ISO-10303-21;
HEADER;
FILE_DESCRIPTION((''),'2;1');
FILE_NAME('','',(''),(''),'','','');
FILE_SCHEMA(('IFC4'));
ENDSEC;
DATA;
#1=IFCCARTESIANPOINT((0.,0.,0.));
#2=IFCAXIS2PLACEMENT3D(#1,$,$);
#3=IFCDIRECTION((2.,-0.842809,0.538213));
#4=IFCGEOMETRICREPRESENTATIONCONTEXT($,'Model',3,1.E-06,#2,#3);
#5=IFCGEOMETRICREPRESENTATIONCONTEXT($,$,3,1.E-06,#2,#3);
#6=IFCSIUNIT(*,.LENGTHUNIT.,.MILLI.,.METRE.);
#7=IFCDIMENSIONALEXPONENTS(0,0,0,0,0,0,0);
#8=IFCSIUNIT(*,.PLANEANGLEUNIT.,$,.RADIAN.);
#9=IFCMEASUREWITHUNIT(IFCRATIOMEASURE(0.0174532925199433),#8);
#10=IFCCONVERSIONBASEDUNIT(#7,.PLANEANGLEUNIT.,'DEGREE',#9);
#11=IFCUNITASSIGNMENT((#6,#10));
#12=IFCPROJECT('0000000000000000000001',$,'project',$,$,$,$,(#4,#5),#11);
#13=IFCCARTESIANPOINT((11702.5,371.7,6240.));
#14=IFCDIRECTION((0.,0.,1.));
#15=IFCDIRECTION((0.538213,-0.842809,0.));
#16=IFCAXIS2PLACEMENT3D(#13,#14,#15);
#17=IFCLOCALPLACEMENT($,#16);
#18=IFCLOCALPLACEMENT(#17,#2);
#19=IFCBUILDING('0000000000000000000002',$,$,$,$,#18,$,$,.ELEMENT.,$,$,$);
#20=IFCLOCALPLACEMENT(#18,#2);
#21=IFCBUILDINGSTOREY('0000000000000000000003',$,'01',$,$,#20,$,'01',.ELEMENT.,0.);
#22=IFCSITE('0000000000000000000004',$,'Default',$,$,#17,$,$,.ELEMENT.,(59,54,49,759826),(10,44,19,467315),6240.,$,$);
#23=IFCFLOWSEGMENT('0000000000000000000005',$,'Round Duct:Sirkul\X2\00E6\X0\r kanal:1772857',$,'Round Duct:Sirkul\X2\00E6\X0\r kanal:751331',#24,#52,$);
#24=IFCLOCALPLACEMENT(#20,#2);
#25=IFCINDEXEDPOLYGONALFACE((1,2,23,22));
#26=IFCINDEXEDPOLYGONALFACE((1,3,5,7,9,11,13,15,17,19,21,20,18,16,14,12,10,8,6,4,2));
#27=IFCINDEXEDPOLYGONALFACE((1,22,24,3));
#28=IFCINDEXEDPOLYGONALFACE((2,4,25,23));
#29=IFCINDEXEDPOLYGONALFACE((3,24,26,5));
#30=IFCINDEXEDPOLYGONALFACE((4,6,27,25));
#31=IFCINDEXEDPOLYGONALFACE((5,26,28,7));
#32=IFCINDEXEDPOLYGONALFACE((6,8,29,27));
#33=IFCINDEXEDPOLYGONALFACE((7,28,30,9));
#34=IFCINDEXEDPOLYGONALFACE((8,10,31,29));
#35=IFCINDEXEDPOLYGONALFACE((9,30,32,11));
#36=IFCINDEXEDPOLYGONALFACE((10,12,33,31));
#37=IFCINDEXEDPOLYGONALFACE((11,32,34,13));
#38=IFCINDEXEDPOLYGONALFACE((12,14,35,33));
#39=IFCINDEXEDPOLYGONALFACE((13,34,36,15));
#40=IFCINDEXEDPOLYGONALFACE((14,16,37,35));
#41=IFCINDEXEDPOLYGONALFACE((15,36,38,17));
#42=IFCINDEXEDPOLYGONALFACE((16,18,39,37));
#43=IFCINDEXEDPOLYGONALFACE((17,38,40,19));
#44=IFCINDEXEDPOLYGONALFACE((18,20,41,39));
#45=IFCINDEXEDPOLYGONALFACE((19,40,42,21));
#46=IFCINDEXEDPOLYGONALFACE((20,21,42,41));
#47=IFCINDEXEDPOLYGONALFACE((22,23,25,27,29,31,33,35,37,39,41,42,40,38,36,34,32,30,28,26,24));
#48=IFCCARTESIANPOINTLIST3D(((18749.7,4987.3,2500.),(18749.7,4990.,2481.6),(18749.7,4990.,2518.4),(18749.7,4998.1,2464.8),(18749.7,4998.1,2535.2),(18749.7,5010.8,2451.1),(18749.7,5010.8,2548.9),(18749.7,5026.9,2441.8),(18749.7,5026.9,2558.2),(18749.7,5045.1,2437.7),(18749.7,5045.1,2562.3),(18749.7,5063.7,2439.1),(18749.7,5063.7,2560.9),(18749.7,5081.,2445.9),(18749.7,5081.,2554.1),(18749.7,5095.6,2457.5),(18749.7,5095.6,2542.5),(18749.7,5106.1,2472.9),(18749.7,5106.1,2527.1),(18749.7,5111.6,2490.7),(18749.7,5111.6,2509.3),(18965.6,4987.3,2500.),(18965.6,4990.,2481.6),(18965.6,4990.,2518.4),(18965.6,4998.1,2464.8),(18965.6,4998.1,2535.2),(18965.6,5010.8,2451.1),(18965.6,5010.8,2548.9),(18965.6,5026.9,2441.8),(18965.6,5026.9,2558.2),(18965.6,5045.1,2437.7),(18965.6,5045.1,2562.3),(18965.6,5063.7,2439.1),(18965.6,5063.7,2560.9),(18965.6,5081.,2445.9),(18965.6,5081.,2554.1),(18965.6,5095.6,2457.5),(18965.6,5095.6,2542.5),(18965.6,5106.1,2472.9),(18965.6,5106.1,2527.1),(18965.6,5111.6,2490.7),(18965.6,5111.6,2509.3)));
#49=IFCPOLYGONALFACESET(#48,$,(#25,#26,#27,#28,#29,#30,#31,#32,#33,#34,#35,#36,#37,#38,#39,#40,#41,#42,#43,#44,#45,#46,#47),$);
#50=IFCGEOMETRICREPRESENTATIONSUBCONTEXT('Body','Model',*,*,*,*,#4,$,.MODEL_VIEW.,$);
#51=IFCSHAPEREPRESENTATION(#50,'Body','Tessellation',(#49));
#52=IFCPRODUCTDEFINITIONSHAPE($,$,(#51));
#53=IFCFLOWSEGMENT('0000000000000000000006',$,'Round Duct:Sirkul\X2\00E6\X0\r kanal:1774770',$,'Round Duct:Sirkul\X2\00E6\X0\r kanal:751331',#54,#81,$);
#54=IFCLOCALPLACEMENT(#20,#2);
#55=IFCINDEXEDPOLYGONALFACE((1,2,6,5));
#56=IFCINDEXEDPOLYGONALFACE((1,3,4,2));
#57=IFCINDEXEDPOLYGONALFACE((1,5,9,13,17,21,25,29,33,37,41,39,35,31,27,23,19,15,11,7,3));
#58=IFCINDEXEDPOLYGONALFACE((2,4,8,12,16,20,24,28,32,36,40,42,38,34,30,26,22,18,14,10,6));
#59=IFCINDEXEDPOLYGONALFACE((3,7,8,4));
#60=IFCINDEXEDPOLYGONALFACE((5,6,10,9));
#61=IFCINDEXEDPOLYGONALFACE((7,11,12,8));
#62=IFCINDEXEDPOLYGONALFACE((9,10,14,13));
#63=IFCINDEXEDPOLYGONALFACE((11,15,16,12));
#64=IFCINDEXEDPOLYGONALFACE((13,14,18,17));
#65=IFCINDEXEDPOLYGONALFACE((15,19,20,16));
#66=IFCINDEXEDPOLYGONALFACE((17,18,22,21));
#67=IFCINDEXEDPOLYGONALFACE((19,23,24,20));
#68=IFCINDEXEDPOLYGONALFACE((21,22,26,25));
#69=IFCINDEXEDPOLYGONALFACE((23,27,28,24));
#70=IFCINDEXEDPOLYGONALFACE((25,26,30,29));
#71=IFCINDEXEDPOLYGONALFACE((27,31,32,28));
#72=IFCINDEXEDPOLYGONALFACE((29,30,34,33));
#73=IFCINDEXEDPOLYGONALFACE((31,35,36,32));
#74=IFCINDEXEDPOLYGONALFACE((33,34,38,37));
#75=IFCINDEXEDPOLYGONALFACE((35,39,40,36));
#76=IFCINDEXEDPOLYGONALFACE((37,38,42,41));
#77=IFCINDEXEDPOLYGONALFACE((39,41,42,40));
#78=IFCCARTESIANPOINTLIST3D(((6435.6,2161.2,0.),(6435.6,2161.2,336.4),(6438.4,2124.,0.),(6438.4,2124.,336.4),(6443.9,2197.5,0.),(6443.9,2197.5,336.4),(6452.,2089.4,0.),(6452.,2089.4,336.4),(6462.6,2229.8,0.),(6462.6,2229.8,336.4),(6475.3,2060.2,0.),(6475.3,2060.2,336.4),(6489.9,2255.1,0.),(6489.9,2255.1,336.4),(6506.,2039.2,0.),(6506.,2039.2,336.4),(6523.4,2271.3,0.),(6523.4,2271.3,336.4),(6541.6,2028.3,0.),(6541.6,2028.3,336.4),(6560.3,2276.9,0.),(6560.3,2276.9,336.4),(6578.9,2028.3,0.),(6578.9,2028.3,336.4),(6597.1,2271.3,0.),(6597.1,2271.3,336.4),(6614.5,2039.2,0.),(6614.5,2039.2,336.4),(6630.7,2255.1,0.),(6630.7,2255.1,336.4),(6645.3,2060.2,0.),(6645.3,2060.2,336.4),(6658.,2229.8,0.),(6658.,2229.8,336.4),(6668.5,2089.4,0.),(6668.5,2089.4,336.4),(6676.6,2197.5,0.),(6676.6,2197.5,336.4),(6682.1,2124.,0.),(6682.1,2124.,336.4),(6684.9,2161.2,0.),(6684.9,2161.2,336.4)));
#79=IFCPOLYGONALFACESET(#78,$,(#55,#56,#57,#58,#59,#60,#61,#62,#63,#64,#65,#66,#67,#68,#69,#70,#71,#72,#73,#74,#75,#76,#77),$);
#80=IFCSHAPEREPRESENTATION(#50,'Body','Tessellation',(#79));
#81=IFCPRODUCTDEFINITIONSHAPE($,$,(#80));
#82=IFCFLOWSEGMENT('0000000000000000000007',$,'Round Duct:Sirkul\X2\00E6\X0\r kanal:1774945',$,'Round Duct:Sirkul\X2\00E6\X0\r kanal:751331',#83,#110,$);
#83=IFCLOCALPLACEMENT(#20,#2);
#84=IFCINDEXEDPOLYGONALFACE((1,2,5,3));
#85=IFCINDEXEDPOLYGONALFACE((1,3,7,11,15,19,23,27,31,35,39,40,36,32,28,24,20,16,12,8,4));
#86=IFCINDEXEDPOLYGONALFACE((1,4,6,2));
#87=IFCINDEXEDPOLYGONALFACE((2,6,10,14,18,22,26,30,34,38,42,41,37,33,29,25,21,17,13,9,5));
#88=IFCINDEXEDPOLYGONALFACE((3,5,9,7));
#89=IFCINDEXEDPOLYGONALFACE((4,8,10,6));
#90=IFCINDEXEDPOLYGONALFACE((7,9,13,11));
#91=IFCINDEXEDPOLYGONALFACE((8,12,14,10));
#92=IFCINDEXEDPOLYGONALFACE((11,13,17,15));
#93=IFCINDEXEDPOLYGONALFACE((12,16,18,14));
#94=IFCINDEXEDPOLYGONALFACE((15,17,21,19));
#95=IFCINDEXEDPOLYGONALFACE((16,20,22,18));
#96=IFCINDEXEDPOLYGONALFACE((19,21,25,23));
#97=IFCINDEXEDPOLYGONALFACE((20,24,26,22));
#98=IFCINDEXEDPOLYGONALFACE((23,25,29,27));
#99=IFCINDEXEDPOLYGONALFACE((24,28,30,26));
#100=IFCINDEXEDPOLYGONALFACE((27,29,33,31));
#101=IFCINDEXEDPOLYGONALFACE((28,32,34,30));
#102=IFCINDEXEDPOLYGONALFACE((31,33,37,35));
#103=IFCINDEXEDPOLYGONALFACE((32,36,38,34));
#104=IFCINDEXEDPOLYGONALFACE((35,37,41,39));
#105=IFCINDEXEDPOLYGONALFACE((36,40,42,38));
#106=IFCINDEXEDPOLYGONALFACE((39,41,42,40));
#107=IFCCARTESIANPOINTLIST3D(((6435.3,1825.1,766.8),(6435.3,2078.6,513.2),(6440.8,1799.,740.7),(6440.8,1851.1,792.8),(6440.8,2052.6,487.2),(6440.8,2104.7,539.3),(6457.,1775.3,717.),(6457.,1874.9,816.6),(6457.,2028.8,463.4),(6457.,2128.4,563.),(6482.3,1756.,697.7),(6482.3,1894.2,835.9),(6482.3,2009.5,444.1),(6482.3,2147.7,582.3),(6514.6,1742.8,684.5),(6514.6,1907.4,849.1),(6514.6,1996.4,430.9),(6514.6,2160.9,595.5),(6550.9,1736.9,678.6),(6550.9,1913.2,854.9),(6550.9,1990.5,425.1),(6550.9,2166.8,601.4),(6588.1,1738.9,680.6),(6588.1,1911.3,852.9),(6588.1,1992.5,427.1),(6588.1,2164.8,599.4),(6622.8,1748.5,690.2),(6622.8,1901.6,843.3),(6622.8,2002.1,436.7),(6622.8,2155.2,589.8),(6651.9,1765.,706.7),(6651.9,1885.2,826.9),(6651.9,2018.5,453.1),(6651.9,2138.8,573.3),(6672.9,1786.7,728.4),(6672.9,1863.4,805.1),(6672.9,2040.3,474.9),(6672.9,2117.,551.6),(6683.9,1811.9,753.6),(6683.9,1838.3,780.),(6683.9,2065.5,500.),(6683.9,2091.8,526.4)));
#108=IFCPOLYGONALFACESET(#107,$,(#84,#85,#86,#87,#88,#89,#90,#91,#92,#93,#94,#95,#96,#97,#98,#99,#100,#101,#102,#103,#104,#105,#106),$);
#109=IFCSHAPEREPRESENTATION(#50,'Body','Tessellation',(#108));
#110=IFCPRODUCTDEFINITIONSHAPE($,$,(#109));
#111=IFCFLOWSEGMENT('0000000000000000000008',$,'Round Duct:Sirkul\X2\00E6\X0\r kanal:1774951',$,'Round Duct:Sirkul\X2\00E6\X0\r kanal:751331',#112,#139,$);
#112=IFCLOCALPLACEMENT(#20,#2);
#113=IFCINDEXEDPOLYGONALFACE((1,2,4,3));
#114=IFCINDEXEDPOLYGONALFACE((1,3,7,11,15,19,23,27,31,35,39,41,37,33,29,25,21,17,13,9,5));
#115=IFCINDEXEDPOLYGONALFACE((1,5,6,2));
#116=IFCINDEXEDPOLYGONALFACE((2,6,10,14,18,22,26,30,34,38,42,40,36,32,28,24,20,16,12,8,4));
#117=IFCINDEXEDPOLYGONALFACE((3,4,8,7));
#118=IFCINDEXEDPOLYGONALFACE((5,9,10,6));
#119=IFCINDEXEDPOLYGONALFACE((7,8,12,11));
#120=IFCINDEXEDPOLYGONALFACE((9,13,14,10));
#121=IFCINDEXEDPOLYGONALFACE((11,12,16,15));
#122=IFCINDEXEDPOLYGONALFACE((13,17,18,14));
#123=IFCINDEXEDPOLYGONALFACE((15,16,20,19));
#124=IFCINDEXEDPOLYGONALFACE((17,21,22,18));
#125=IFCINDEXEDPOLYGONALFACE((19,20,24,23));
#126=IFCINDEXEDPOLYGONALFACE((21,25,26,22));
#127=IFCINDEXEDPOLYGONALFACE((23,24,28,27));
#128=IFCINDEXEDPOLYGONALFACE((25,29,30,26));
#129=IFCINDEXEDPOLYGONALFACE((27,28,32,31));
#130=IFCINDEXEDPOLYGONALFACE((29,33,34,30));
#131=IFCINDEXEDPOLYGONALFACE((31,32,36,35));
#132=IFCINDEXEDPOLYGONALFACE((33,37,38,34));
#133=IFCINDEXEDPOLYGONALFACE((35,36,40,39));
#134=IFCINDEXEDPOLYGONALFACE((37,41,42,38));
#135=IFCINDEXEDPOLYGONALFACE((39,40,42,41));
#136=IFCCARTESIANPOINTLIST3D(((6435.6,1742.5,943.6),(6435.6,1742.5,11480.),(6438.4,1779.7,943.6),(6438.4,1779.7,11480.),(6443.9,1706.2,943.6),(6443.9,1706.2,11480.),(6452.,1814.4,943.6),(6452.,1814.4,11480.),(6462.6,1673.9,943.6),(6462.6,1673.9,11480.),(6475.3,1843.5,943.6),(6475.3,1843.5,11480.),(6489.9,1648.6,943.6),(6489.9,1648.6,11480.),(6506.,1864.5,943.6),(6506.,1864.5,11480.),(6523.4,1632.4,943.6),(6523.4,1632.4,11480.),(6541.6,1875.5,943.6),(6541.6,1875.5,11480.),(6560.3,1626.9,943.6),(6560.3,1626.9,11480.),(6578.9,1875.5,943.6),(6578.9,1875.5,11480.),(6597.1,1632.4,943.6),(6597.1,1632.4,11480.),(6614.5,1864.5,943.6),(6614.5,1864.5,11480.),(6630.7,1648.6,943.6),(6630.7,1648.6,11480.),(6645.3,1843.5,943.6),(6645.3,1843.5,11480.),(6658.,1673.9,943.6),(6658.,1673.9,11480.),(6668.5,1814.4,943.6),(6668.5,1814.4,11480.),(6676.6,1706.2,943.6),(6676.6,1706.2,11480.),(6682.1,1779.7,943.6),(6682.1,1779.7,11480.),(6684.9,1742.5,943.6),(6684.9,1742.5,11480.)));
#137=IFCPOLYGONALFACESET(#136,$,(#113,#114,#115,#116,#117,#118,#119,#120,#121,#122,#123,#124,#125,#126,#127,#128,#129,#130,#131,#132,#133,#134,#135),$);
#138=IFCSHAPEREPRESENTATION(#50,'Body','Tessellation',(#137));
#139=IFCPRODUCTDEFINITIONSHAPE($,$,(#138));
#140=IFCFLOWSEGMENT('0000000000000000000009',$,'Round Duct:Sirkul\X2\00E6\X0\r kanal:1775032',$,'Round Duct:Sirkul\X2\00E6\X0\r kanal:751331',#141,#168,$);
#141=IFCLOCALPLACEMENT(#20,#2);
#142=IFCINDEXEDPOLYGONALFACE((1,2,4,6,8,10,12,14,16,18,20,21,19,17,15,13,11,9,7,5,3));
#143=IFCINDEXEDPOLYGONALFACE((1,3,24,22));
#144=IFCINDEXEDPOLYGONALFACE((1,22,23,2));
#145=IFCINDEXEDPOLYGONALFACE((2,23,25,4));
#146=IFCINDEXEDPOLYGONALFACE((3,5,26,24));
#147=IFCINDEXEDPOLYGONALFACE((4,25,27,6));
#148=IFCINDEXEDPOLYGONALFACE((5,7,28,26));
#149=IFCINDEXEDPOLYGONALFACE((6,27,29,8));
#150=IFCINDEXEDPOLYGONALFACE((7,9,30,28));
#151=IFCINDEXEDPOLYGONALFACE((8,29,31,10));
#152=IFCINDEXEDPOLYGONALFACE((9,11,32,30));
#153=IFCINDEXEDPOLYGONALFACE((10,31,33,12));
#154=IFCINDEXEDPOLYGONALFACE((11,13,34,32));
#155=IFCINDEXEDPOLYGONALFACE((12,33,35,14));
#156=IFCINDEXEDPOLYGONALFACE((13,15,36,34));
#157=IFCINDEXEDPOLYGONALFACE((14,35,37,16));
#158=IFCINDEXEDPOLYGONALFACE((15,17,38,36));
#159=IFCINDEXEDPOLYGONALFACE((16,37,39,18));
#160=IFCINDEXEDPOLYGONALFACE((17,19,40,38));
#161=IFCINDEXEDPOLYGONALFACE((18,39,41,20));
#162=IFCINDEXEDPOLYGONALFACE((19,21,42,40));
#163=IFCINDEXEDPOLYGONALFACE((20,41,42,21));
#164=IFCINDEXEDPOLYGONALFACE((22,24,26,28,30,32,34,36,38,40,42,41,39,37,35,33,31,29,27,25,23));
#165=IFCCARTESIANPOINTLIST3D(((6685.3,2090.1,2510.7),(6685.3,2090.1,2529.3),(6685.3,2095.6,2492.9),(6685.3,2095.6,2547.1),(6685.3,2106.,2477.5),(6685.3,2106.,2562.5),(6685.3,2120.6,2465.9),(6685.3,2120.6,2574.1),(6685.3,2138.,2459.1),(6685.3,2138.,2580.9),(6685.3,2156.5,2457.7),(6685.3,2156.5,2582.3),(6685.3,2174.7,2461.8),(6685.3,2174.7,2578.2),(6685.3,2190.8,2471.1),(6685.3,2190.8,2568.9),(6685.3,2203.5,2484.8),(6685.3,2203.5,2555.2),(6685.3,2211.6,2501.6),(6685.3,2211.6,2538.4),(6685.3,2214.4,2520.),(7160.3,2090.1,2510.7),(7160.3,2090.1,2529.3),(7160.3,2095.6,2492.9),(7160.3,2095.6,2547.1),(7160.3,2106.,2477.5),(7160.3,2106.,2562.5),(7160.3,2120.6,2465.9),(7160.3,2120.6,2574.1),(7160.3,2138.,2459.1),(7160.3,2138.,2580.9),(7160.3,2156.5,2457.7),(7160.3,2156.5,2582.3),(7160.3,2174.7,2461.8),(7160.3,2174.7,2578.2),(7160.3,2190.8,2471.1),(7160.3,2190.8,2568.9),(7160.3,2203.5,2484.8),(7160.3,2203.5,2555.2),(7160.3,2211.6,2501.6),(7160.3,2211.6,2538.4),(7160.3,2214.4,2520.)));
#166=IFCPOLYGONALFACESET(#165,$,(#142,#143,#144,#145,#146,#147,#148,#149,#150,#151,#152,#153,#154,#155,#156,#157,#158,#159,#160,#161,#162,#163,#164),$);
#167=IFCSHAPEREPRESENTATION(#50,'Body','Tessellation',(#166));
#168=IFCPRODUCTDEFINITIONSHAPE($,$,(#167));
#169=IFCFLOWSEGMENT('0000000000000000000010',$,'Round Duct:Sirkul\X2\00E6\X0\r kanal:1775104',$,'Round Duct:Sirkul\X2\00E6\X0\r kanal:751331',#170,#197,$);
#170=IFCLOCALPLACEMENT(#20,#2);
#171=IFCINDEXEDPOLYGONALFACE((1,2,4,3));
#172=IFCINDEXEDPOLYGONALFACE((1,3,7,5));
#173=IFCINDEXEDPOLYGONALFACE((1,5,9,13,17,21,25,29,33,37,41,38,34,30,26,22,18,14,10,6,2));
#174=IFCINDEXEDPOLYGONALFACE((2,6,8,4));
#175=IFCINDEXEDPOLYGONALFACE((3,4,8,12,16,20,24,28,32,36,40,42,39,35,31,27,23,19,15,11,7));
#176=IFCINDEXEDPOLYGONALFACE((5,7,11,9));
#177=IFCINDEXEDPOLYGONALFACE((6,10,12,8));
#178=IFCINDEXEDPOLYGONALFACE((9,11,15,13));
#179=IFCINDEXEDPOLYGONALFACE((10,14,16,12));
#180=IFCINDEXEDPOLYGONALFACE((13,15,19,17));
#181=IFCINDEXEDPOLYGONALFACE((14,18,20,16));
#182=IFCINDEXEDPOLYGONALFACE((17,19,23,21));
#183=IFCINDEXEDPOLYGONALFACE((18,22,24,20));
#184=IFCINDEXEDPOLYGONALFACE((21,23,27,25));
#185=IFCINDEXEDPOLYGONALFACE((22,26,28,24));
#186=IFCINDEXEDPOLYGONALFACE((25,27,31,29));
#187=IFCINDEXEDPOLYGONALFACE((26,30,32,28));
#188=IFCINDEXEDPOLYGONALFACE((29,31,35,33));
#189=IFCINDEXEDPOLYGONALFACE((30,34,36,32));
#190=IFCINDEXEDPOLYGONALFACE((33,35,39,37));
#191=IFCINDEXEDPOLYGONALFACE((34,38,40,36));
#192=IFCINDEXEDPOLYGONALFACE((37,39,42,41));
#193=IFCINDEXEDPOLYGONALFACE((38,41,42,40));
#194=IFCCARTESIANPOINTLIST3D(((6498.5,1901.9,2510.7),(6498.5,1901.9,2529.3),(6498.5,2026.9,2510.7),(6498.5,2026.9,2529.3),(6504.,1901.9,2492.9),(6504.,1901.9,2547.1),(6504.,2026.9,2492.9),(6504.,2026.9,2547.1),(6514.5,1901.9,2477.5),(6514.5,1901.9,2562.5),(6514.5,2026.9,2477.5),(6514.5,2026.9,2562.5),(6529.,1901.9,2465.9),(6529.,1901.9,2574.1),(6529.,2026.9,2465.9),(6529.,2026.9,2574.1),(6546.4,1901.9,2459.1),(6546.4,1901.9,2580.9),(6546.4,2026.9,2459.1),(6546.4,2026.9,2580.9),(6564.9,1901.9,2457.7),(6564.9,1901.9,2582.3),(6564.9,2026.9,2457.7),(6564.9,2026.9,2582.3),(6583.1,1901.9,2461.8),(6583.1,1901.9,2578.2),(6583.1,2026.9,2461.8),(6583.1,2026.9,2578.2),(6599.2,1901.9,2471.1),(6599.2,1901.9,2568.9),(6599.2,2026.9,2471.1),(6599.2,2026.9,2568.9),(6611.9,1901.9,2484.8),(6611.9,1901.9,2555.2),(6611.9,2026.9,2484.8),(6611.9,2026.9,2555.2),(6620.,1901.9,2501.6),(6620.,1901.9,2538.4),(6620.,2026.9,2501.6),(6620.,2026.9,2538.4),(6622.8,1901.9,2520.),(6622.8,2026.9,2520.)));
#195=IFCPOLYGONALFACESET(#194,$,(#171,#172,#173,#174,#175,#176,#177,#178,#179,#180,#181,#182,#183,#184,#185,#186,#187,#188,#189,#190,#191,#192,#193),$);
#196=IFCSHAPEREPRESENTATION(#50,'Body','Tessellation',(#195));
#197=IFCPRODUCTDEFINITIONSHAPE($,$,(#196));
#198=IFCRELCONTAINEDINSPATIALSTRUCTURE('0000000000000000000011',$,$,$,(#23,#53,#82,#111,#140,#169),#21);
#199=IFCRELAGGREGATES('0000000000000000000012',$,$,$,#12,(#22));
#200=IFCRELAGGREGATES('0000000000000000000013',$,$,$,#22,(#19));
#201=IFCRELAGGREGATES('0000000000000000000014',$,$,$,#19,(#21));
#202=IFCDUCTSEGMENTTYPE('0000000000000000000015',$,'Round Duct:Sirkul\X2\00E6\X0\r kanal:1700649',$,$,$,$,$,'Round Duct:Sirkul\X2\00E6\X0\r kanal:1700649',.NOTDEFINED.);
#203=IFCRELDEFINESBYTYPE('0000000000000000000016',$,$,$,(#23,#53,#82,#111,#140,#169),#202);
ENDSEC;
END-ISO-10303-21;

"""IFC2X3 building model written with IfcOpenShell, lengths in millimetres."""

from ifc_helpers import new_model, entity, si_unit, converted_unit, direction, frame, frame_2d, origin, origin_2d_with_axis, place, context, subcontext, project, spatial, circle, extrude, type_object, element, save


model = new_model("IFC2X3")

# Units and contexts
model_context = context("Model", 3, precision=1e-06, world=origin(), true_north=direction((2.0, -0.842809, 0.538213)))
context_of_model = context(None, 3, precision=1e-06, world=origin(), true_north=direction((2.0, -0.842809, 0.538213)))
body_context = subcontext(model_context, "Body", "Model", "MODEL_VIEW")
ifc_project = project(units=[si_unit("LENGTHUNIT", "METRE", prefix="MILLI"), converted_unit("PLANEANGLEUNIT", "DEGREE", entity("IfcRatioMeasure", 0.0174532925199433), si_unit("PLANEANGLEUNIT", "RADIAN"), dimensions=[0, 0, 0, 0, 0, 0, 0])], contexts=[model_context, context_of_model])

# Site, building, storey
site_placement = place(None, frame((11702.5, 371.7, 6240.0), z_axis=(0.0, 0.0, 1.0), x_axis=(0.538213, -0.842809, 0.0)))
site = spatial("IfcSite", under=ifc_project, at=site_placement, Name="Default", CompositionType="ELEMENT", RefLatitude=(59, 54, 49, 759826), RefLongitude=(10, 44, 19, 467315), RefElevation=6240.0)
building_placement = place(site_placement, origin())
building = spatial("IfcBuilding", under=site, at=building_placement, CompositionType="ELEMENT")
storey_placement = place(building_placement, origin())
storey = spatial("IfcBuildingStorey", under=building, at=storey_placement, Name="01", LongName="01", CompositionType="ELEMENT", Elevation=0.0)

# Flow segments
duct_segment_type = type_object("IfcDuctSegmentType", Name="Round Duct:Sirkulær kanal:1700649", ElementType="Round Duct:Sirkulær kanal:1700649", PredefinedType="NOTDEFINED")
flow_segment_1_placement = place(storey_placement, origin())
element("IfcFlowSegment", 1, at=flow_segment_1_placement, inside=storey, type_object=duct_segment_type, Name="Round Duct:Sirkulær kanal:1772857", ObjectType="Round Duct:Sirkulær kanal:751331", context=body_context, shape_type="SweptSolid", body=[
    extrude(circle(Radius=62.5, at=origin_2d_with_axis()), frame((18749.7, 5049.8, 2500.0), z_axis=(1.0, 0.0, 0.0), x_axis=(0.0, -1.0, 0.0)), (0.0, 0.0, 1.0), 215.9),
])
flow_segment_2_placement = place(storey_placement, origin())
element("IfcFlowSegment", 2, at=flow_segment_2_placement, inside=storey, type_object=duct_segment_type, Name="Round Duct:Sirkulær kanal:1774770", ObjectType="Round Duct:Sirkulær kanal:751331", context=body_context, shape_type="SweptSolid", body=[
    extrude(circle(Radius=125.0, at=origin_2d_with_axis()), frame((6560.3, 2151.9, 0.0), z_axis=(0.0, 0.0, 1.0), x_axis=(0.0, 1.0, 0.0)), (0.0, 0.0, 1.0), 336.4),
])
flow_segment_3_placement = place(storey_placement, origin())
element("IfcFlowSegment", 3, at=flow_segment_3_placement, inside=storey, type_object=duct_segment_type, Name="Round Duct:Sirkulær kanal:1774945", ObjectType="Round Duct:Sirkulær kanal:751331", context=body_context, shape_type="SweptSolid", body=[
    extrude(circle(Radius=125.0, at=frame_2d((0.0, 0.0), x_axis=(1.0, 0.0))), frame((6560.3, 2078.6, 513.2), z_axis=(0.0, -0.707107, 0.707107), x_axis=(-1.0, 0.0, 0.0)), (0.0, 0.0, 1.0), 358.6),
])
flow_segment_4_placement = place(storey_placement, origin())
element("IfcFlowSegment", 4, at=flow_segment_4_placement, inside=storey, type_object=duct_segment_type, Name="Round Duct:Sirkulær kanal:1774951", ObjectType="Round Duct:Sirkulær kanal:751331", context=body_context, shape_type="SweptSolid", body=[
    extrude(circle(Radius=125.0, at=frame_2d((0.0, 0.0), x_axis=(1.0, 0.0))), frame((6560.3, 1751.9, 943.6), z_axis=(0.0, 0.0, 1.0), x_axis=(0.0, -1.0, 0.0)), (0.0, 0.0, 1.0), 10536.4),
])
flow_segment_5_placement = place(storey_placement, origin())
element("IfcFlowSegment", 5, at=flow_segment_5_placement, inside=storey, type_object=duct_segment_type, Name="Round Duct:Sirkulær kanal:1775032", ObjectType="Round Duct:Sirkulær kanal:751331", context=body_context, shape_type="SweptSolid", body=[
    extrude(circle(Radius=62.5, at=frame_2d((0.0, 0.0), x_axis=(1.0, 0.0))), frame((6685.3, 2151.9, 2520.0), z_axis=(1.0, 0.0, 0.0), x_axis=(0.0, 1.0, 0.0)), (0.0, 0.0, 1.0), 475.0),
])
flow_segment_6_placement = place(storey_placement, origin())
element("IfcFlowSegment", 6, at=flow_segment_6_placement, inside=storey, type_object=duct_segment_type, Name="Round Duct:Sirkulær kanal:1775104", ObjectType="Round Duct:Sirkulær kanal:751331", context=body_context, shape_type="SweptSolid", body=[
    extrude(circle(Radius=62.5, at=frame_2d((0.0, 0.0), x_axis=(1.0, 0.0))), frame((6560.3, 1901.9, 2520.0), z_axis=(0.0, 1.0, 0.0), x_axis=(1.0, 0.0, 0.0)), (0.0, 0.0, 1.0), 125.0),
])

save(model, "model.ifc")
